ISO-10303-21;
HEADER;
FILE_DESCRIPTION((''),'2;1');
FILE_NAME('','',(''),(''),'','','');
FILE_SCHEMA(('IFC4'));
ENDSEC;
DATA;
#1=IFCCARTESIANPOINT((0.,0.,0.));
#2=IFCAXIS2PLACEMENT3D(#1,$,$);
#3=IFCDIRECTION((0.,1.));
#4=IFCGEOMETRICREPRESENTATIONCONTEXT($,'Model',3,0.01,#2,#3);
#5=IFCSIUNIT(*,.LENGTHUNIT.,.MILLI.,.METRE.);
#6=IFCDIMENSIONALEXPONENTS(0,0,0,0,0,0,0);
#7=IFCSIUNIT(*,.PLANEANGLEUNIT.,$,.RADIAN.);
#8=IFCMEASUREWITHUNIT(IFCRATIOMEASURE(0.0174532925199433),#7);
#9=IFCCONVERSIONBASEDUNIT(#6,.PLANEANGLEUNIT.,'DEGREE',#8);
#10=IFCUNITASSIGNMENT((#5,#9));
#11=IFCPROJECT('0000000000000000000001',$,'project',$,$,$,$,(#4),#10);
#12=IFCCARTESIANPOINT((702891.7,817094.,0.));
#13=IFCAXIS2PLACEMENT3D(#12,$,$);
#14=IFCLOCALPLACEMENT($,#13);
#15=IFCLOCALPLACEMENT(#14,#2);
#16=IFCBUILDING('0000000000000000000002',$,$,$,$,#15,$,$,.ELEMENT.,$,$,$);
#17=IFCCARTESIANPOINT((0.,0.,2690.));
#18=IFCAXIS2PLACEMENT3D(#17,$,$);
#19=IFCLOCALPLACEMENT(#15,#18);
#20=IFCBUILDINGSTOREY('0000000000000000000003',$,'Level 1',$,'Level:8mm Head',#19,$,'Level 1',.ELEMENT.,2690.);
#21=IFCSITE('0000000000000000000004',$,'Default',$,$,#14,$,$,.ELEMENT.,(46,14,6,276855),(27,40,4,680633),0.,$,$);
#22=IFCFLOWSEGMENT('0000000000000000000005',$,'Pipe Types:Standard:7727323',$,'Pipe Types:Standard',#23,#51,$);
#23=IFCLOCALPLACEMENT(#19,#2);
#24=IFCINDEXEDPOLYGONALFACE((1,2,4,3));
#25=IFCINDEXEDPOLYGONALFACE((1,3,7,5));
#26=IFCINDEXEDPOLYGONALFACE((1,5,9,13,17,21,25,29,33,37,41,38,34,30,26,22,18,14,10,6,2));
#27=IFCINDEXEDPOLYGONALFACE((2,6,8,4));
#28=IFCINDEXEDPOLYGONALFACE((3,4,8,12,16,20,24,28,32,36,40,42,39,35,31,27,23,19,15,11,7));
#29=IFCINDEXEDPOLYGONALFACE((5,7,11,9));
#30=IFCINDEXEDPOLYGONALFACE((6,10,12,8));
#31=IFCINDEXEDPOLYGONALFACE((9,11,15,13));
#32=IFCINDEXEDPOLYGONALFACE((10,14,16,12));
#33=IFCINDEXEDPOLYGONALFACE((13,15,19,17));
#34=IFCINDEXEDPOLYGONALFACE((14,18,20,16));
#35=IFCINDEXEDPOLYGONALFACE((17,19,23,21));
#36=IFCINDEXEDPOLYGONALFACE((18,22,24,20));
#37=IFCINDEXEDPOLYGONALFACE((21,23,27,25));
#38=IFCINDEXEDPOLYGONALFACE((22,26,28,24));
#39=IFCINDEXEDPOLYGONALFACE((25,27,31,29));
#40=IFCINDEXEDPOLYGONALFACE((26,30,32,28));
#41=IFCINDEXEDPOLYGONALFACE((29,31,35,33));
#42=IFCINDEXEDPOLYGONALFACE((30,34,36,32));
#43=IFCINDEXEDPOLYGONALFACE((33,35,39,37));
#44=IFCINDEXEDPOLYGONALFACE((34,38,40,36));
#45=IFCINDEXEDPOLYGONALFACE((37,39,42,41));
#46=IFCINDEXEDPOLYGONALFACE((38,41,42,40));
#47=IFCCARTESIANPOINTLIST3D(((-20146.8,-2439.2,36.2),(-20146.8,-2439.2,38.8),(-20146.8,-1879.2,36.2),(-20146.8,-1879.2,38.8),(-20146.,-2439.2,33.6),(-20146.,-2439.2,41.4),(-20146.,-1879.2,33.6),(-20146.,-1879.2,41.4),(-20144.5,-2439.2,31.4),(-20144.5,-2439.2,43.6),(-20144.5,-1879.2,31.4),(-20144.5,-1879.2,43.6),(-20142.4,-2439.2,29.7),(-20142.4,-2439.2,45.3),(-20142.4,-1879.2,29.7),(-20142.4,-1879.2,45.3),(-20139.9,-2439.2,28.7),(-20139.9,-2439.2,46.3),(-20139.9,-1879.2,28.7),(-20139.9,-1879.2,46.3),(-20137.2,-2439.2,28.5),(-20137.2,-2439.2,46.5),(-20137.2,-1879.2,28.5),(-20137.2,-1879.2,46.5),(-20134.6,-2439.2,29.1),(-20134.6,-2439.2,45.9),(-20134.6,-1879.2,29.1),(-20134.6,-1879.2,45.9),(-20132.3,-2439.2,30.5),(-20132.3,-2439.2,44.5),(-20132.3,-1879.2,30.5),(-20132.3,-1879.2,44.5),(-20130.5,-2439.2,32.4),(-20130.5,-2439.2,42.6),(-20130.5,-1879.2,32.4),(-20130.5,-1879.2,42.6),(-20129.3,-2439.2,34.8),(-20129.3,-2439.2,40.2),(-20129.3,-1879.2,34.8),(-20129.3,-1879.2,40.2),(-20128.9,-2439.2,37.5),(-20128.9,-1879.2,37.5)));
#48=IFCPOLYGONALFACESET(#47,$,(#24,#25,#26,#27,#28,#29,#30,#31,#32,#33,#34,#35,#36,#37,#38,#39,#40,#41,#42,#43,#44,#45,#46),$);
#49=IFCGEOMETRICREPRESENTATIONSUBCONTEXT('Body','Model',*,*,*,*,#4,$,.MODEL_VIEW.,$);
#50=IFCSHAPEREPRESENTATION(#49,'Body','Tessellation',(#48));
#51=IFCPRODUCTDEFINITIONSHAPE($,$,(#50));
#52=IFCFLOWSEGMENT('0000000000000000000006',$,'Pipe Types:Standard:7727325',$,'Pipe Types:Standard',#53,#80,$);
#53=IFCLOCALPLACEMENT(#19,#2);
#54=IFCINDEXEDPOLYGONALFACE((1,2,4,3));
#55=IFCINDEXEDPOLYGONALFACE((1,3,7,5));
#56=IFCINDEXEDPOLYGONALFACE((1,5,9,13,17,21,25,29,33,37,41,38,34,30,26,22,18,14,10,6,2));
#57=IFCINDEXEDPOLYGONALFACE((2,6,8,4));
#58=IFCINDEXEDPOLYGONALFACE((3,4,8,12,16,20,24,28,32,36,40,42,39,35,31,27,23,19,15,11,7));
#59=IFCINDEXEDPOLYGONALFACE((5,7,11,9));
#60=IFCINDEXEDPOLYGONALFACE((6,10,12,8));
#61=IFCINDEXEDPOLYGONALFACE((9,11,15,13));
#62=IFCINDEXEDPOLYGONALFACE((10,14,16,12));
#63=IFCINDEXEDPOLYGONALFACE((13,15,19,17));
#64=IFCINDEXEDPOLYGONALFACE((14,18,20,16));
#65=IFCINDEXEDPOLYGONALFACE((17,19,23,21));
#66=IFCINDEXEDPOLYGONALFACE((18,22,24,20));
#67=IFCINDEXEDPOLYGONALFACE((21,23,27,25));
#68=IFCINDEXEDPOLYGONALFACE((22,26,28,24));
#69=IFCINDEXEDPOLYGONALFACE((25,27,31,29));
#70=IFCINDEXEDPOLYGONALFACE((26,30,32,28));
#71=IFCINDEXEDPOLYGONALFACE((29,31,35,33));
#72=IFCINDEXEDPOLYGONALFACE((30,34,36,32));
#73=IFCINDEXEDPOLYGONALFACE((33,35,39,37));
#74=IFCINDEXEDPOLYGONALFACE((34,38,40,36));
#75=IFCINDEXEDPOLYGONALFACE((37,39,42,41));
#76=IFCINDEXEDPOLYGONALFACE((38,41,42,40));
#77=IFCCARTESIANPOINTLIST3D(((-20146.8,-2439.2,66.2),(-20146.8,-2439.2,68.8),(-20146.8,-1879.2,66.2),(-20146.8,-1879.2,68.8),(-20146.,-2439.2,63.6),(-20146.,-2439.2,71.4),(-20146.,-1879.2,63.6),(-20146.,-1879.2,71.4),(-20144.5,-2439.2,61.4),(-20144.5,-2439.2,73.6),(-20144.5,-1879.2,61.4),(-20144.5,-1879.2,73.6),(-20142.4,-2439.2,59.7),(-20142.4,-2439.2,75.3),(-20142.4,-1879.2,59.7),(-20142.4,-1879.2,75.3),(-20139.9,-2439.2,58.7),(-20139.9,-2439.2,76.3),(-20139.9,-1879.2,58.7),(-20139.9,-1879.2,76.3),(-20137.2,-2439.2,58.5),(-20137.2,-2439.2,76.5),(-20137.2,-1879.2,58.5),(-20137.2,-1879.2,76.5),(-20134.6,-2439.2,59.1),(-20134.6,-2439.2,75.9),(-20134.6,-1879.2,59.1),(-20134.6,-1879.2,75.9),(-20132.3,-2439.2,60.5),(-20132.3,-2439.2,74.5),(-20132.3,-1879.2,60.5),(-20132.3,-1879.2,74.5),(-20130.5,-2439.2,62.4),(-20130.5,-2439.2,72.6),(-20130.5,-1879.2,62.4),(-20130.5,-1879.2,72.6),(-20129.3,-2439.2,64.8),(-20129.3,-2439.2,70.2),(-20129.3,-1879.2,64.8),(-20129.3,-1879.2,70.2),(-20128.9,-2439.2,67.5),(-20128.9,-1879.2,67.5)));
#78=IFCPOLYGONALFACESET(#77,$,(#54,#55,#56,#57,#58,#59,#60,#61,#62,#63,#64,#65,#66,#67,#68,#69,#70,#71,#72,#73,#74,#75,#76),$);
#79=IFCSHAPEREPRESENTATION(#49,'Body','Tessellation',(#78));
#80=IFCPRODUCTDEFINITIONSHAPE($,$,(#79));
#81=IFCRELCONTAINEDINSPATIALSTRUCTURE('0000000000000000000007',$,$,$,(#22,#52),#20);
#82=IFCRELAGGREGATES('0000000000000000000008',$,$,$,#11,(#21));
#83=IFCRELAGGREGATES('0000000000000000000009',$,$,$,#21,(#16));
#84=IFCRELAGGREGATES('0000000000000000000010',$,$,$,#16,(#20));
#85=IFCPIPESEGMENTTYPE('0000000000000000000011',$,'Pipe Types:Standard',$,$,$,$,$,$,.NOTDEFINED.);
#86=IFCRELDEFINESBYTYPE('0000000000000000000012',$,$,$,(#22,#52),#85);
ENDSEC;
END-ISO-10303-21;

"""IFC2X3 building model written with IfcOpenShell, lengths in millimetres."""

from ifc_helpers import new_model, entity, si_unit, converted_unit, direction, frame, origin, origin_2d_with_axis, place, context, subcontext, project, spatial, circle, extrude, type_object, element, save


model = new_model("IFC2X3")

# Units and contexts
model_context = context("Model", 3, precision=0.01, world=origin(), true_north=direction((0.0, 1.0)))
body_context = subcontext(model_context, "Body", "Model", "MODEL_VIEW")
ifc_project = project(units=[si_unit("LENGTHUNIT", "METRE", prefix="MILLI"), converted_unit("PLANEANGLEUNIT", "DEGREE", entity("IfcRatioMeasure", 0.0174532925199433), si_unit("PLANEANGLEUNIT", "RADIAN"), dimensions=[0, 0, 0, 0, 0, 0, 0])], contexts=[model_context])

# Site, building, storey
site_placement = place(None, frame((702891.7, 817094.0, 0.0)))
site = spatial("IfcSite", under=ifc_project, at=site_placement, Name="Default", CompositionType="ELEMENT", RefLatitude=(46, 14, 6, 276855), RefLongitude=(27, 40, 4, 680633), RefElevation=0.0)
building_placement = place(site_placement, origin())
building = spatial("IfcBuilding", under=site, at=building_placement, CompositionType="ELEMENT")
storey_placement = place(building_placement, frame((0.0, 0.0, 2690.0)))
storey = spatial("IfcBuildingStorey", under=building, at=storey_placement, Name="Level 1", ObjectType="Level:8mm Head", LongName="Level 1", CompositionType="ELEMENT", Elevation=2690.0)

# Flow segments
pipe_segment_type = type_object("IfcPipeSegmentType", Name="Pipe Types:Standard", PredefinedType="NOTDEFINED")
flow_segment_1_placement = place(storey_placement, origin())
element("IfcFlowSegment", 1, at=flow_segment_1_placement, inside=storey, type_object=pipe_segment_type, Name="Pipe Types:Standard:7727323", ObjectType="Pipe Types:Standard", context=body_context, shape_type="SweptSolid", body=[
    extrude(circle(Radius=9.0, at=origin_2d_with_axis()), frame((-20137.9, -2439.2, 37.5), z_axis=(0.0, 1.0, 0.0), x_axis=(1.0, 0.0, 0.0)), (0.0, 0.0, 1.0), 560.0),
])
flow_segment_2_placement = place(storey_placement, origin())
element("IfcFlowSegment", 2, at=flow_segment_2_placement, inside=storey, type_object=pipe_segment_type, Name="Pipe Types:Standard:7727325", ObjectType="Pipe Types:Standard", context=body_context, shape_type="SweptSolid", body=[
    extrude(circle(Radius=9.0, at=origin_2d_with_axis()), frame((-20137.9, -2439.2, 67.5), z_axis=(0.0, 1.0, 0.0), x_axis=(1.0, 0.0, 0.0)), (0.0, 0.0, 1.0), 560.0),
])

save(model, "model.ifc")
